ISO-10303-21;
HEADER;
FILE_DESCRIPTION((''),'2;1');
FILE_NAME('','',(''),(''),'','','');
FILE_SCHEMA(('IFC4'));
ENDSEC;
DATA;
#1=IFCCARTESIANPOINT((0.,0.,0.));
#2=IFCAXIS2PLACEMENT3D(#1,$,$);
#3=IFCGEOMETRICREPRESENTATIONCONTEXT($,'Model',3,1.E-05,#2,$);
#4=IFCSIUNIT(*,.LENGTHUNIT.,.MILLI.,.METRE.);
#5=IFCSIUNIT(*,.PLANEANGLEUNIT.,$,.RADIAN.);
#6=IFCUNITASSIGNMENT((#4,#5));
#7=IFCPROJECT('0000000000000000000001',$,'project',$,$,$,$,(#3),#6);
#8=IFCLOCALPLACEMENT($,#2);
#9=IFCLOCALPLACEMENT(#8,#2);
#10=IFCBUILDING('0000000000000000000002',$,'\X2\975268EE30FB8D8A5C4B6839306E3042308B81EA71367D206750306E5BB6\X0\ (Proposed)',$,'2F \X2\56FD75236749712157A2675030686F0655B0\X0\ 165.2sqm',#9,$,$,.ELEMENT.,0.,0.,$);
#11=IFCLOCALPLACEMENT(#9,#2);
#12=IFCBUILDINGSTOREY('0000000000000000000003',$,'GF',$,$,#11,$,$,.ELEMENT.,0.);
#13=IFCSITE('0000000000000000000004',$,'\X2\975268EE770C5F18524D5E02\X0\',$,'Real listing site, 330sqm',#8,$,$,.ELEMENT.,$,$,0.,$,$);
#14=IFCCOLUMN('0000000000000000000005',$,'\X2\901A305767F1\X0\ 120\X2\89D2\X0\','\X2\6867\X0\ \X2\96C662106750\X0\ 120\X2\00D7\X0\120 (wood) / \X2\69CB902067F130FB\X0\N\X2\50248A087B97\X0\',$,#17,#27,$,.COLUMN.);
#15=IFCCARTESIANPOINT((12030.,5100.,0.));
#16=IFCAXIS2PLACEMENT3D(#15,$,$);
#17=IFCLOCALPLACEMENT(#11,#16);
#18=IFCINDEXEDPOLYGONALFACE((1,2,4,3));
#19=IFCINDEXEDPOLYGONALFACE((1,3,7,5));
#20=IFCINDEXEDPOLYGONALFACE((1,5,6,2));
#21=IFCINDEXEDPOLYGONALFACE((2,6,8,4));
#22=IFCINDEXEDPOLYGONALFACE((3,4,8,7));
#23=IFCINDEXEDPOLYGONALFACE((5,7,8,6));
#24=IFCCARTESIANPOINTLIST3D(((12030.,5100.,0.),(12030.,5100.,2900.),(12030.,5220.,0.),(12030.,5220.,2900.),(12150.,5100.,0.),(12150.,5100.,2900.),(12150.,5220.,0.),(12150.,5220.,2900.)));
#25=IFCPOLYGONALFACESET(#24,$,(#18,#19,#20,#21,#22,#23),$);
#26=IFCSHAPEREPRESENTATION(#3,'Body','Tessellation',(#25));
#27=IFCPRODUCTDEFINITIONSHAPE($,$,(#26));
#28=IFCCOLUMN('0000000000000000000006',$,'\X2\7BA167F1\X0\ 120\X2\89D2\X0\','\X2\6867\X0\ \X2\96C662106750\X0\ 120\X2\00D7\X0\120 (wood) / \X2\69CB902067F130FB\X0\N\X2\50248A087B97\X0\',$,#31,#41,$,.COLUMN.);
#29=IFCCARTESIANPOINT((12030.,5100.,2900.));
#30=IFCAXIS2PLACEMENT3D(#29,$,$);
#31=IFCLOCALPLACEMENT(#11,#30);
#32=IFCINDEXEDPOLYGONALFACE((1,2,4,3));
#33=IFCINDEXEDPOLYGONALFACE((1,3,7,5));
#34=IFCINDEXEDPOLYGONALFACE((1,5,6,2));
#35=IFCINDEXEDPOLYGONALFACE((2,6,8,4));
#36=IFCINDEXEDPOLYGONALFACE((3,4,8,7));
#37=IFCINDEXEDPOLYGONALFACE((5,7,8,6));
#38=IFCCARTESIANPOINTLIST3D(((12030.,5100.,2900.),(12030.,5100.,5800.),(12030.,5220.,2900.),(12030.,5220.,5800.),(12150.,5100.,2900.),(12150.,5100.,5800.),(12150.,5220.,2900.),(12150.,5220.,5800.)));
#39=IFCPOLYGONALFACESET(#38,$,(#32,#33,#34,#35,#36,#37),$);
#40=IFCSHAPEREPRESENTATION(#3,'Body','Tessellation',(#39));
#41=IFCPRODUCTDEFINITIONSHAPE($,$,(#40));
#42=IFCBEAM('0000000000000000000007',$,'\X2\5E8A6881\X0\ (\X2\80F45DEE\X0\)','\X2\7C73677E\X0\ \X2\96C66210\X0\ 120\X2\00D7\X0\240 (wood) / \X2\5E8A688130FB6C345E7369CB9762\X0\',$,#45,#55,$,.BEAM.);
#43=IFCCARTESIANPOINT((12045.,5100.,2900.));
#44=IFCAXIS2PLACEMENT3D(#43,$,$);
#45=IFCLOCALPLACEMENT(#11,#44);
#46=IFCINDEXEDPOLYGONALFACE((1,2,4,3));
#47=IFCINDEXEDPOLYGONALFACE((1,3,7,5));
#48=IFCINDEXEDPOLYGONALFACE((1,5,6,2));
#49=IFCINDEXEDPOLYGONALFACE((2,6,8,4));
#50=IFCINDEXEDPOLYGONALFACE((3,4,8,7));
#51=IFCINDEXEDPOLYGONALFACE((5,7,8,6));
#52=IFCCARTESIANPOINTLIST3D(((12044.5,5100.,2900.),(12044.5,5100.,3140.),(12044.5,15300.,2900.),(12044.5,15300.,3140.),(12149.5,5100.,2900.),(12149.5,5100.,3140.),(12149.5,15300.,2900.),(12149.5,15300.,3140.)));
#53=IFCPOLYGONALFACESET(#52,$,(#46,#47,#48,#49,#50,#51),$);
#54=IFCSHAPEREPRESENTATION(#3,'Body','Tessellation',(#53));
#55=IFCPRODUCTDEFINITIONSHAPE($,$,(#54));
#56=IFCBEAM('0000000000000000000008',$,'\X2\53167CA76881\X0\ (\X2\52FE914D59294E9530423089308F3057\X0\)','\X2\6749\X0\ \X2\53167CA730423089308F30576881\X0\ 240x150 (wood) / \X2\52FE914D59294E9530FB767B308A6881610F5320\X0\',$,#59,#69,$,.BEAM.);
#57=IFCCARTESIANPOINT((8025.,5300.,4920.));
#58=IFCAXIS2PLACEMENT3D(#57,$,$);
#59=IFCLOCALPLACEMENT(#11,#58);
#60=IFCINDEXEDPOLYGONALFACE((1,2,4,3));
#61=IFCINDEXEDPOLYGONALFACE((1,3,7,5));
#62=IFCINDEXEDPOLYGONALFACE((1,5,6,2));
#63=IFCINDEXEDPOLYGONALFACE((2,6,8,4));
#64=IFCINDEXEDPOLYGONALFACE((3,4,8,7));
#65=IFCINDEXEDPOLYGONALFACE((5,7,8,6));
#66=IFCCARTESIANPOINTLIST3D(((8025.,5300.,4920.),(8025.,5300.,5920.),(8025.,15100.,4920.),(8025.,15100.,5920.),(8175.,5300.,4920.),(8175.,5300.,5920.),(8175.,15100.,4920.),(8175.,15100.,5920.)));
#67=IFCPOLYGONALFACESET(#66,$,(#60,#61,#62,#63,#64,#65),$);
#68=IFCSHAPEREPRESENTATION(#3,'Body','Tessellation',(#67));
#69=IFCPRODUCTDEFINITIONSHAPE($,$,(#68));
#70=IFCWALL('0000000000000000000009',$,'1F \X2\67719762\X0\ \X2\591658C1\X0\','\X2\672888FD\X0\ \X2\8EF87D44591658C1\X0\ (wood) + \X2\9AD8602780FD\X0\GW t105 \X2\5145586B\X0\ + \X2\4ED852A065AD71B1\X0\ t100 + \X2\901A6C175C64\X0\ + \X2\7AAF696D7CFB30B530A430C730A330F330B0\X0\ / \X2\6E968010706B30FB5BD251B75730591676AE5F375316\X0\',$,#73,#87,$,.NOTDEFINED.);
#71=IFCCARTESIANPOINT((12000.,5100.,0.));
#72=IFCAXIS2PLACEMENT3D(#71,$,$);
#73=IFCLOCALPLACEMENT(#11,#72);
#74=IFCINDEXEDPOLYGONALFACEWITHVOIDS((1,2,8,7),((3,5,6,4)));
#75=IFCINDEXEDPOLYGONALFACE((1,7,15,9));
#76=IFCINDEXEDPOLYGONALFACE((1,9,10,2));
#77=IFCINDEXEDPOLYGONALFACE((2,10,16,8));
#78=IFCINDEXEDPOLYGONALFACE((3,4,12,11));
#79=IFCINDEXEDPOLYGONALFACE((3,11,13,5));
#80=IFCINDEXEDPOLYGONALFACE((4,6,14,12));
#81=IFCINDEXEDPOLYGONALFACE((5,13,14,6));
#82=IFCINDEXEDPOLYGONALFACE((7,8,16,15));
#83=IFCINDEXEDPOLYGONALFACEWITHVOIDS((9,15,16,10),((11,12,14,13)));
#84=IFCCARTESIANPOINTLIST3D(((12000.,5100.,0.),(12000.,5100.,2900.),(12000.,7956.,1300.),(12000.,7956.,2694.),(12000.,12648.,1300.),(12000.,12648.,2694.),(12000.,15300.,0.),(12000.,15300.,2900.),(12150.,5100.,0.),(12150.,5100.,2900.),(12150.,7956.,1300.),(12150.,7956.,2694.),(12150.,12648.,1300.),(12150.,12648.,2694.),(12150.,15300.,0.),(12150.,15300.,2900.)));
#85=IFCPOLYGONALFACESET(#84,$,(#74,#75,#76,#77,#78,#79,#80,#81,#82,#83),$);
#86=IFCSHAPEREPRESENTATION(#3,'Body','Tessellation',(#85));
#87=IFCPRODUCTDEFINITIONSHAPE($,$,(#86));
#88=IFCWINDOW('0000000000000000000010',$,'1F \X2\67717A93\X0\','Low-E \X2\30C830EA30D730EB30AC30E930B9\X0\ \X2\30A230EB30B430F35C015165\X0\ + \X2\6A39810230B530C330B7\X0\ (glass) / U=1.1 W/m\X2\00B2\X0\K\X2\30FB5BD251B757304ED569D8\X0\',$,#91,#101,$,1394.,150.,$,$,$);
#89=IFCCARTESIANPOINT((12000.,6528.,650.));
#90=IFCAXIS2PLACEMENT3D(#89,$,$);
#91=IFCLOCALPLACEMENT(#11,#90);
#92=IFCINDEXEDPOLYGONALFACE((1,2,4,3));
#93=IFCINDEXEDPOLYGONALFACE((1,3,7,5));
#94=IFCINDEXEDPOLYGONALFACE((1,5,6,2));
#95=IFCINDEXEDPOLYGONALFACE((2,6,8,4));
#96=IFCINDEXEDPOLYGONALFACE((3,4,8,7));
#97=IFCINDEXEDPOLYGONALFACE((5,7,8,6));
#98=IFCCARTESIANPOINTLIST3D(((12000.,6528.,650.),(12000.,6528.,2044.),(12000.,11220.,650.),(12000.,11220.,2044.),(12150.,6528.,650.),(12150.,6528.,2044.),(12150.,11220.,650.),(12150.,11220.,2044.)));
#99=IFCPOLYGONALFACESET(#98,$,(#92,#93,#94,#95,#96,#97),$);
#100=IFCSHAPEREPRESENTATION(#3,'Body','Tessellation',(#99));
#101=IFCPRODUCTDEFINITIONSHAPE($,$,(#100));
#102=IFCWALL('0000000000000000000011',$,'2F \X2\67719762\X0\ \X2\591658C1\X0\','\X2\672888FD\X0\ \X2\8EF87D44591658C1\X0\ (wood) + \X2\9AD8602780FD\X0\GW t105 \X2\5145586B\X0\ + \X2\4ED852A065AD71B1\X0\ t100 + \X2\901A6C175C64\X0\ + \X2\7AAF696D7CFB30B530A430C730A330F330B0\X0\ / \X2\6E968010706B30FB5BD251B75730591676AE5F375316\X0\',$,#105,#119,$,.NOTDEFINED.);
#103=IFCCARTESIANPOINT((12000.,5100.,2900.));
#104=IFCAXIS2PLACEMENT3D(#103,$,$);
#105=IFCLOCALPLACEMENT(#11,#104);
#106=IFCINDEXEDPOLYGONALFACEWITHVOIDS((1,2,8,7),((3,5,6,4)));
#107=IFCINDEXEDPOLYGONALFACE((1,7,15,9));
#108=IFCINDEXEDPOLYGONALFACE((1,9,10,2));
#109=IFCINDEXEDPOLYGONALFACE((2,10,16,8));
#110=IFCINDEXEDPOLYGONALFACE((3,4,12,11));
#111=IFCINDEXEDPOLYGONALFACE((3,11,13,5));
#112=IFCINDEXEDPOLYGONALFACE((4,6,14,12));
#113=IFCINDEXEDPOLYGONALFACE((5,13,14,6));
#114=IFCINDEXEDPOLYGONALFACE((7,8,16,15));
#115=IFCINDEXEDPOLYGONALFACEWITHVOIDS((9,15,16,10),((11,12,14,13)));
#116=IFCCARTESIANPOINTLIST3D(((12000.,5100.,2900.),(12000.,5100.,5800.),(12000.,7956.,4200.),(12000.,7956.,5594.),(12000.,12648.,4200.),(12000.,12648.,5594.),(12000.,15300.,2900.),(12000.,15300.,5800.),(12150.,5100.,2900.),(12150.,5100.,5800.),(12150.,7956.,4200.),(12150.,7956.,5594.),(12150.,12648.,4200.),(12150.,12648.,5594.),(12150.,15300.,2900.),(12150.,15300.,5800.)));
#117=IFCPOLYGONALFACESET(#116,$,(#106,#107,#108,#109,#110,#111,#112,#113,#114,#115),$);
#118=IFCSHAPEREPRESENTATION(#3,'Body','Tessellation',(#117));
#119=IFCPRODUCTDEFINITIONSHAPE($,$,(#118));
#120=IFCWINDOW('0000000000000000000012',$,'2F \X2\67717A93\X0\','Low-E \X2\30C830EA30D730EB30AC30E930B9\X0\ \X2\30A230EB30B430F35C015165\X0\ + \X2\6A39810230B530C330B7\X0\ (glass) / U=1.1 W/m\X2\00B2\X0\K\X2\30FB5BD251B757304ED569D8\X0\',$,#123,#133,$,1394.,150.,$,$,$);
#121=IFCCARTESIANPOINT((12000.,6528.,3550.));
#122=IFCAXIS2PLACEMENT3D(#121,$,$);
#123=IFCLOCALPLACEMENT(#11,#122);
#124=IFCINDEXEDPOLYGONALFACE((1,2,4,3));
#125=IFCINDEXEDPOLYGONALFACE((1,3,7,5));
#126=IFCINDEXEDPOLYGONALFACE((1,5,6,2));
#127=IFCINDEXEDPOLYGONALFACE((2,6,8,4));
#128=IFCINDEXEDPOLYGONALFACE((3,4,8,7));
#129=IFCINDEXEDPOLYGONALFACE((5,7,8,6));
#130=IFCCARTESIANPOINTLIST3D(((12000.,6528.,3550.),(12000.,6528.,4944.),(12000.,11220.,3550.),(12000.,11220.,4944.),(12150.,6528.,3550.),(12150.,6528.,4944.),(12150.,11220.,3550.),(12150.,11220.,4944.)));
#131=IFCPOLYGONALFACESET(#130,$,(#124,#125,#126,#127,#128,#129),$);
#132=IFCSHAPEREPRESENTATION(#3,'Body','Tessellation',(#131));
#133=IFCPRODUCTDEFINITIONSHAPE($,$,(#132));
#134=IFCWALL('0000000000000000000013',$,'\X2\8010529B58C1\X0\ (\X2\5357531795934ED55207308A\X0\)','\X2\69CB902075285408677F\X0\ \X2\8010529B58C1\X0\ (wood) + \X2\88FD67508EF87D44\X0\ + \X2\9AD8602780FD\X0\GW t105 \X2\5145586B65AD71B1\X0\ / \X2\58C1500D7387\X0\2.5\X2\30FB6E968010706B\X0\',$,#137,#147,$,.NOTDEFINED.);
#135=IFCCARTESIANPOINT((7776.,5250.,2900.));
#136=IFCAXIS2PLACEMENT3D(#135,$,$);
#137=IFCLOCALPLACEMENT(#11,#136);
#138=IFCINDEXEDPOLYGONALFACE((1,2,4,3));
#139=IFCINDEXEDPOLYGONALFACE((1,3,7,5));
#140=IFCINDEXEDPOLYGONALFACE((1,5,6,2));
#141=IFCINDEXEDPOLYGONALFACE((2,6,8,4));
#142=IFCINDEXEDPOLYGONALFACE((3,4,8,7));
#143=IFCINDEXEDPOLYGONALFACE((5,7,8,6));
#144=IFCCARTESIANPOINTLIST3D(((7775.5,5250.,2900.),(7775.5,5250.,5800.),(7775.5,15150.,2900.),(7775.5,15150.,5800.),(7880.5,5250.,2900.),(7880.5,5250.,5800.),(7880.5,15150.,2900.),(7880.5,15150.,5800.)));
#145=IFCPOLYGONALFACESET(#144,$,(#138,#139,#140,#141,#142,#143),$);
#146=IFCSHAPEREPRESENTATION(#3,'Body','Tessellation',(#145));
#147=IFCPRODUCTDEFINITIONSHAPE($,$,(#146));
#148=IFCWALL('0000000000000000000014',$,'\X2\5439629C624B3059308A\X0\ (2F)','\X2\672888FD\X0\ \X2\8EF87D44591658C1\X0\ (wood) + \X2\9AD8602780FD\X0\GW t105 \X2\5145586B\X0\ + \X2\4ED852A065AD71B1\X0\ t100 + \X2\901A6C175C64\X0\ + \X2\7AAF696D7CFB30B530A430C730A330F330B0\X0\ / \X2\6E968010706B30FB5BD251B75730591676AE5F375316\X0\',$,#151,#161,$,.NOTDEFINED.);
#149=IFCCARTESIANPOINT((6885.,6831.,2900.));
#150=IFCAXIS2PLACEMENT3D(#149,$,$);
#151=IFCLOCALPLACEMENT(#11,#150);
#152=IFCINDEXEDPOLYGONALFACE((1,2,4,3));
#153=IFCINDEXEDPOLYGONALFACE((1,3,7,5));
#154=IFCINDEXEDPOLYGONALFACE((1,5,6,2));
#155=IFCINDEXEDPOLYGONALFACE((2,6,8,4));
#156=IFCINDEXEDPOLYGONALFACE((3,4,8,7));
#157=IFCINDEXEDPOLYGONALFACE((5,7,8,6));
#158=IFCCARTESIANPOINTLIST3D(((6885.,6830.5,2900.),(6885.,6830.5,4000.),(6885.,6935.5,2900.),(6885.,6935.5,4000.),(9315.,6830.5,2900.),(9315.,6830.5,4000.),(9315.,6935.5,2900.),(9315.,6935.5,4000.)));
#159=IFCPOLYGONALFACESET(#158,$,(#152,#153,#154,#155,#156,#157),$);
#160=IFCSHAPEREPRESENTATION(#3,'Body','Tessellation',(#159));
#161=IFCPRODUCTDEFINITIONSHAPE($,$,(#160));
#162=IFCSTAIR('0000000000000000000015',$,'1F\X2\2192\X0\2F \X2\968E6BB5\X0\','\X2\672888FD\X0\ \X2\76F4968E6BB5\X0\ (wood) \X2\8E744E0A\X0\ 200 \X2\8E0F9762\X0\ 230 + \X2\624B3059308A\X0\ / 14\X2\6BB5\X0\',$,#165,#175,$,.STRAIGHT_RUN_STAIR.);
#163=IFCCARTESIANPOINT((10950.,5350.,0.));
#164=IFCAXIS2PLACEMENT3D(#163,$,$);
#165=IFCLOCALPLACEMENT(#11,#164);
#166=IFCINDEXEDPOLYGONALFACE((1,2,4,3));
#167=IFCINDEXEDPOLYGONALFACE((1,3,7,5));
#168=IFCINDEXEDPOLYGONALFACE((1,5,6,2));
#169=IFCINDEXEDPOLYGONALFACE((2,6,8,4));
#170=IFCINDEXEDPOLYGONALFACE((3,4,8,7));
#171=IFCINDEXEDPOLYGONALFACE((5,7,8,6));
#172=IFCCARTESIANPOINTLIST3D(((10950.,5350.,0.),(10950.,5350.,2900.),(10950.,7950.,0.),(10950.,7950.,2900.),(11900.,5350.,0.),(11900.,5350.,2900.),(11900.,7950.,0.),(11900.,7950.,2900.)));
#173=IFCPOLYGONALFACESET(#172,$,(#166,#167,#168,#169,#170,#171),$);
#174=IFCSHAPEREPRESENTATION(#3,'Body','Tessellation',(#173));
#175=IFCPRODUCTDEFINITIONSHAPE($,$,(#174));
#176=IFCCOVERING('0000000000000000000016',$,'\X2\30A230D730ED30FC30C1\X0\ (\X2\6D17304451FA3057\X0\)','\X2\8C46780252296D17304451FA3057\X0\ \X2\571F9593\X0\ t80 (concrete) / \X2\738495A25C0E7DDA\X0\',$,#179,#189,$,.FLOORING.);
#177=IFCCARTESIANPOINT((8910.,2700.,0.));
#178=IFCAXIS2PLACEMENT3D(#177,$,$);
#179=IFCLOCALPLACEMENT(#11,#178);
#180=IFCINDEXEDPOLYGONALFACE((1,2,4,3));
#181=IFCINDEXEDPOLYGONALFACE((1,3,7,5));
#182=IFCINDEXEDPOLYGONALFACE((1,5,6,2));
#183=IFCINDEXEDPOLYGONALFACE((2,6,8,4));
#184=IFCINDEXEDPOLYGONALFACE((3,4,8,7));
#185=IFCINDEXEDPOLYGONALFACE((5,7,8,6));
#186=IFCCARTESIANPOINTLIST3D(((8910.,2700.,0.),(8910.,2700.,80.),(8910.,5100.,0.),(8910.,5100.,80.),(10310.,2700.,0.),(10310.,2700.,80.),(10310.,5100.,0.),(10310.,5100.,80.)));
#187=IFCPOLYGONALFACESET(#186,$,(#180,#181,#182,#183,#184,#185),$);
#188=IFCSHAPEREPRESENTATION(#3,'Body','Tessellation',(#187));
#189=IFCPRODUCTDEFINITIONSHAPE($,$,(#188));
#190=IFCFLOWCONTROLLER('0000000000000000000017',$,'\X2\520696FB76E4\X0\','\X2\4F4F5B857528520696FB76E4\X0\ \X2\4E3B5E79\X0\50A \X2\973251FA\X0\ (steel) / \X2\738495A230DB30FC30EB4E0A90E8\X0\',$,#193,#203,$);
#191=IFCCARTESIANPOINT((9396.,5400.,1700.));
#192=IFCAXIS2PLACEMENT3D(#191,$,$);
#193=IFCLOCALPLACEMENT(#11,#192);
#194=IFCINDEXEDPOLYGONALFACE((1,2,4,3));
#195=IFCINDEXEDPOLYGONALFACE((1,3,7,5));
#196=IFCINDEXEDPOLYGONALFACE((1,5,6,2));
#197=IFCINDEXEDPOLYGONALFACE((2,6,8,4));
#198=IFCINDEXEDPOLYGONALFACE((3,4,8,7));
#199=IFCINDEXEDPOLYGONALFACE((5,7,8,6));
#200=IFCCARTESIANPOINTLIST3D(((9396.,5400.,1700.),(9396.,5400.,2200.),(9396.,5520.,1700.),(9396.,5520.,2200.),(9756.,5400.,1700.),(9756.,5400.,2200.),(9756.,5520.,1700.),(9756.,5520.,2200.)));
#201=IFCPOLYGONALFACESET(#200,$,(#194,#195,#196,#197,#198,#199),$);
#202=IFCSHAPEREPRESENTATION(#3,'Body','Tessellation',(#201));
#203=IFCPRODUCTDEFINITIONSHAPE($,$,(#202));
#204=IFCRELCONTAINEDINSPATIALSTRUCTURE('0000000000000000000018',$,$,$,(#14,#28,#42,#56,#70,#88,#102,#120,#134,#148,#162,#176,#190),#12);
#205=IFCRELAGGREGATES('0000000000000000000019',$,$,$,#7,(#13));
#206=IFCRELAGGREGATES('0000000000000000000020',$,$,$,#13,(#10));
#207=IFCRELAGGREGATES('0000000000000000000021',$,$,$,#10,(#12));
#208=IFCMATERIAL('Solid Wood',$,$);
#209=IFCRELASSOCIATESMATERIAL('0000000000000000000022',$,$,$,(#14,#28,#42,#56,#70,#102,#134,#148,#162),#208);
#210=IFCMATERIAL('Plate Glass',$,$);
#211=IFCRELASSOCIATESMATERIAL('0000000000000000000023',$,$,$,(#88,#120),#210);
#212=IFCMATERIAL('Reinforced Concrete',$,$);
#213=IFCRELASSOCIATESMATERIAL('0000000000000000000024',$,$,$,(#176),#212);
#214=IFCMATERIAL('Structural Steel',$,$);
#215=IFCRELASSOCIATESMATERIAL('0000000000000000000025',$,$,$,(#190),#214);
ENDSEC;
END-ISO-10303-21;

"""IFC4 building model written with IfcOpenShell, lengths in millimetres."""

from ifc_helpers import new_model, si_unit, frame, frame_2d, origin, place, context, project, spatial, rectangle, extrude, material, element, fill, save


model = new_model("IFC4")

# Units and contexts
model_context = context("Model", 3, precision=1e-05, world=origin())
ifc_project = project(units=[si_unit("LENGTHUNIT", "METRE", prefix="MILLI"), si_unit("PLANEANGLEUNIT", "RADIAN")], contexts=[model_context])

# Site, building, storey
site_placement = place(None, origin())
site = spatial("IfcSite", under=ifc_project, at=site_placement, Name="青森県弘前市", ObjectType="Real listing site, 330sqm", CompositionType="ELEMENT", RefElevation=0.0)
building_placement = place(site_placement, origin())
building = spatial("IfcBuilding", under=site, at=building_placement, Name="青森・越屋根のある自然素材の家 (Proposed)", ObjectType="2F 国産杉無垢材と漆喰 165.2sqm", CompositionType="ELEMENT", ElevationOfRefHeight=0.0, ElevationOfTerrain=0.0)
storey_placement = place(building_placement, origin())
storey = spatial("IfcBuildingStorey", under=building, at=storey_placement, Name="GF", CompositionType="ELEMENT", Elevation=0.0)

# Columns
ifc_material_1 = material(Name="Solid Wood")
column_1_placement = place(storey_placement, frame((12030.0, 5100.0, 0.0)))
element("IfcColumn", 1, at=column_1_placement, inside=storey, material=ifc_material_1, Name="通し柱 120角", Description="桧 集成材 120×120 (wood) / 構造柱・N値計算", PredefinedType="COLUMN", context=model_context, shape_type="SweptSolid", body=[
    extrude(rectangle(XDim=120.0, YDim=120.0, at=frame_2d((60.0, 60.0))), frame((12030.0, 5100.0, 0.0)), (0.0, 0.0, 1.0), 2900.0),
])
column_2_placement = place(storey_placement, frame((12030.0, 5100.0, 2900.0)))
element("IfcColumn", 2, at=column_2_placement, inside=storey, material=ifc_material_1, Name="管柱 120角", Description="桧 集成材 120×120 (wood) / 構造柱・N値計算", PredefinedType="COLUMN", context=model_context, shape_type="SweptSolid", body=[
    extrude(rectangle(XDim=120.0, YDim=120.0, at=frame_2d((60.0, 60.0))), frame((12030.0, 5100.0, 2900.0)), (0.0, 0.0, 1.0), 2900.0),
])

# Beams
beam_1_placement = place(storey_placement, frame((12045.0, 5100.0, 2900.0)))
element("IfcBeam", 3, at=beam_1_placement, inside=storey, material=ifc_material_1, Name="床梁 (胴差)", Description="米松 集成 120×240 (wood) / 床梁・水平構面", PredefinedType="BEAM", context=model_context, shape_type="SweptSolid", body=[
    extrude(rectangle(XDim=105.0, YDim=10200.0, at=frame_2d((52.0, 5100.0))), frame((12045.0, 5100.0, 2900.0)), (0.0, 0.0, 1.0), 240.0),
])
beam_2_placement = place(storey_placement, frame((8025.0, 5300.0, 4920.0)))
element("IfcBeam", 4, at=beam_2_placement, inside=storey, material=ifc_material_1, Name="化粧梁 (勾配天井あらわし)", Description="杉 化粧あらわし梁 240x150 (wood) / 勾配天井・登り梁意匠", PredefinedType="BEAM", context=model_context, shape_type="SweptSolid", body=[
    extrude(rectangle(XDim=150.0, YDim=9800.0, at=frame_2d((75.0, 4900.0))), frame((8025.0, 5300.0, 4920.0)), (0.0, 0.0, 1.0), 1000.0),
])

# Wall, opening, window
wall_1_placement = place(storey_placement, frame((12000.0, 5100.0, 0.0)))
wall_1 = element("IfcWall", 5, at=wall_1_placement, inside=storey, material=ifc_material_1, Name="1F 東面 外壁", Description="木製 軸組外壁 (wood) + 高性能GW t105 充填 + 付加断熱 t100 + 通気層 + 窯業系サイディング / 準耐火・寒冷地外皮強化", PredefinedType="NOTDEFINED", context=model_context, shape_type="SweptSolid", body=[
    extrude(rectangle(XDim=150.0, YDim=10200.0, at=frame_2d((75.0, 5100.0))), frame((12000.0, 5100.0, 0.0)), (0.0, 0.0, 1.0), 2900.0),
])
opening_1_placement = place(storey_placement, frame((12000.0, 6528.0, 650.0)))
opening_1 = element("IfcOpeningElement", 6, at=opening_1_placement, cuts=wall_1, PredefinedType="NOTDEFINED", context=model_context, shape_type="SweptSolid", body=[
    extrude(rectangle(XDim=150.0, YDim=4692.0, at=frame_2d((75.0, 2346.0))), frame((12000.0, 6528.0, 650.0)), (0.0, 0.0, 1.0), 1394.0),
])
ifc_material_2 = material(Name="Plate Glass")
window_1_placement = place(storey_placement, frame((12000.0, 6528.0, 650.0)))
window_1 = element("IfcWindow", 7, at=window_1_placement, inside=storey, material=ifc_material_2, Name="1F 東窓", Description="Low-E トリプルガラス アルゴン封入 + 樹脂サッシ (glass) / U=1.1 W/m²K・寒冷地仕様", OverallHeight=1394.0, OverallWidth=150.0, context=model_context, shape_type="SweptSolid", body=[
    extrude(rectangle(XDim=150.0, YDim=4692.0, at=frame_2d((75.0, 2346.0))), frame((12000.0, 6528.0, 650.0)), (0.0, 0.0, 1.0), 1394.0),
])
fill(opening_1, window_1)

# Wall, opening, window
wall_2_placement = place(storey_placement, frame((12000.0, 5100.0, 2900.0)))
wall_2 = element("IfcWall", 8, at=wall_2_placement, inside=storey, material=ifc_material_1, Name="2F 東面 外壁", Description="木製 軸組外壁 (wood) + 高性能GW t105 充填 + 付加断熱 t100 + 通気層 + 窯業系サイディング / 準耐火・寒冷地外皮強化", PredefinedType="NOTDEFINED", context=model_context, shape_type="SweptSolid", body=[
    extrude(rectangle(XDim=150.0, YDim=10200.0, at=frame_2d((75.0, 5100.0))), frame((12000.0, 5100.0, 2900.0)), (0.0, 0.0, 1.0), 2900.0),
])
opening_2_placement = place(storey_placement, frame((12000.0, 6528.0, 3550.0)))
opening_2 = element("IfcOpeningElement", 9, at=opening_2_placement, cuts=wall_2, PredefinedType="NOTDEFINED", context=model_context, shape_type="SweptSolid", body=[
    extrude(rectangle(XDim=150.0, YDim=4692.0, at=frame_2d((75.0, 2346.0))), frame((12000.0, 6528.0, 3550.0)), (0.0, 0.0, 1.0), 1394.0),
])
window_2_placement = place(storey_placement, frame((12000.0, 6528.0, 3550.0)))
window_2 = element("IfcWindow", 10, at=window_2_placement, inside=storey, material=ifc_material_2, Name="2F 東窓", Description="Low-E トリプルガラス アルゴン封入 + 樹脂サッシ (glass) / U=1.1 W/m²K・寒冷地仕様", OverallHeight=1394.0, OverallWidth=150.0, context=model_context, shape_type="SweptSolid", body=[
    extrude(rectangle(XDim=150.0, YDim=4692.0, at=frame_2d((75.0, 2346.0))), frame((12000.0, 6528.0, 3550.0)), (0.0, 0.0, 1.0), 1394.0),
])
fill(opening_2, window_2)

# Walls
wall_3_placement = place(storey_placement, frame((7776.0, 5250.0, 2900.0)))
element("IfcWall", 11, at=wall_3_placement, inside=storey, material=ifc_material_1, Name="耐力壁 (南北間仕切り)", Description="構造用合板 耐力壁 (wood) + 製材軸組 + 高性能GW t105 充填断熱 / 壁倍率2.5・準耐火", PredefinedType="NOTDEFINED", context=model_context, shape_type="SweptSolid", body=[
    extrude(rectangle(XDim=105.0, YDim=9900.0, at=frame_2d((52.0, 4950.0))), frame((7776.0, 5250.0, 2900.0)), (0.0, 0.0, 1.0), 2900.0),
])
wall_4_placement = place(storey_placement, frame((6885.0, 6831.0, 2900.0)))
element("IfcWall", 12, at=wall_4_placement, inside=storey, material=ifc_material_1, Name="吹抜手すり (2F)", Description="木製 軸組外壁 (wood) + 高性能GW t105 充填 + 付加断熱 t100 + 通気層 + 窯業系サイディング / 準耐火・寒冷地外皮強化", PredefinedType="NOTDEFINED", context=model_context, shape_type="SweptSolid", body=[
    extrude(rectangle(XDim=2430.0, YDim=105.0, at=frame_2d((1215.0, 52.0))), frame((6885.0, 6831.0, 2900.0)), (0.0, 0.0, 1.0), 1100.0),
])

# Stair
stair_placement = place(storey_placement, frame((10950.0, 5350.0, 0.0)))
element("IfcStair", 13, at=stair_placement, inside=storey, material=ifc_material_1, Name="1F→2F 階段", Description="木製 直階段 (wood) 蹴上 200 踏面 230 + 手すり / 14段", PredefinedType="STRAIGHT_RUN_STAIR", context=model_context, shape_type="SweptSolid", body=[
    extrude(rectangle(XDim=950.0, YDim=2600.0, at=frame_2d((475.0, 1300.0))), frame((10950.0, 5350.0, 0.0)), (0.0, 0.0, 1.0), 2900.0),
])

# Covering
ifc_material_3 = material(Name="Reinforced Concrete")
covering_placement = place(storey_placement, frame((8910.0, 2700.0, 0.0)))
element("IfcCovering", 14, at=covering_placement, inside=storey, material=ifc_material_3, Name="アプローチ (洗い出し)", Description="豆砂利洗い出し 土間 t80 (concrete) / 玄関導線", PredefinedType="FLOORING", context=model_context, shape_type="SweptSolid", body=[
    extrude(rectangle(XDim=1400.0, YDim=2400.0, at=frame_2d((700.0, 1200.0))), frame((8910.0, 2700.0, 0.0)), (0.0, 0.0, 1.0), 80.0),
])

# Flow controller
ifc_material_4 = material(Name="Structural Steel")
flow_controller_placement = place(storey_placement, frame((9396.0, 5400.0, 1700.0)))
element("IfcFlowController", 15, at=flow_controller_placement, inside=storey, material=ifc_material_4, Name="分電盤", Description="住宅用分電盤 主幹50A 露出 (steel) / 玄関ホール上部", context=model_context, shape_type="SweptSolid", body=[
    extrude(rectangle(XDim=360.0, YDim=120.0, at=frame_2d((180.0, 60.0))), frame((9396.0, 5400.0, 1700.0)), (0.0, 0.0, 1.0), 500.0),
])

save(model, "model.ifc")
